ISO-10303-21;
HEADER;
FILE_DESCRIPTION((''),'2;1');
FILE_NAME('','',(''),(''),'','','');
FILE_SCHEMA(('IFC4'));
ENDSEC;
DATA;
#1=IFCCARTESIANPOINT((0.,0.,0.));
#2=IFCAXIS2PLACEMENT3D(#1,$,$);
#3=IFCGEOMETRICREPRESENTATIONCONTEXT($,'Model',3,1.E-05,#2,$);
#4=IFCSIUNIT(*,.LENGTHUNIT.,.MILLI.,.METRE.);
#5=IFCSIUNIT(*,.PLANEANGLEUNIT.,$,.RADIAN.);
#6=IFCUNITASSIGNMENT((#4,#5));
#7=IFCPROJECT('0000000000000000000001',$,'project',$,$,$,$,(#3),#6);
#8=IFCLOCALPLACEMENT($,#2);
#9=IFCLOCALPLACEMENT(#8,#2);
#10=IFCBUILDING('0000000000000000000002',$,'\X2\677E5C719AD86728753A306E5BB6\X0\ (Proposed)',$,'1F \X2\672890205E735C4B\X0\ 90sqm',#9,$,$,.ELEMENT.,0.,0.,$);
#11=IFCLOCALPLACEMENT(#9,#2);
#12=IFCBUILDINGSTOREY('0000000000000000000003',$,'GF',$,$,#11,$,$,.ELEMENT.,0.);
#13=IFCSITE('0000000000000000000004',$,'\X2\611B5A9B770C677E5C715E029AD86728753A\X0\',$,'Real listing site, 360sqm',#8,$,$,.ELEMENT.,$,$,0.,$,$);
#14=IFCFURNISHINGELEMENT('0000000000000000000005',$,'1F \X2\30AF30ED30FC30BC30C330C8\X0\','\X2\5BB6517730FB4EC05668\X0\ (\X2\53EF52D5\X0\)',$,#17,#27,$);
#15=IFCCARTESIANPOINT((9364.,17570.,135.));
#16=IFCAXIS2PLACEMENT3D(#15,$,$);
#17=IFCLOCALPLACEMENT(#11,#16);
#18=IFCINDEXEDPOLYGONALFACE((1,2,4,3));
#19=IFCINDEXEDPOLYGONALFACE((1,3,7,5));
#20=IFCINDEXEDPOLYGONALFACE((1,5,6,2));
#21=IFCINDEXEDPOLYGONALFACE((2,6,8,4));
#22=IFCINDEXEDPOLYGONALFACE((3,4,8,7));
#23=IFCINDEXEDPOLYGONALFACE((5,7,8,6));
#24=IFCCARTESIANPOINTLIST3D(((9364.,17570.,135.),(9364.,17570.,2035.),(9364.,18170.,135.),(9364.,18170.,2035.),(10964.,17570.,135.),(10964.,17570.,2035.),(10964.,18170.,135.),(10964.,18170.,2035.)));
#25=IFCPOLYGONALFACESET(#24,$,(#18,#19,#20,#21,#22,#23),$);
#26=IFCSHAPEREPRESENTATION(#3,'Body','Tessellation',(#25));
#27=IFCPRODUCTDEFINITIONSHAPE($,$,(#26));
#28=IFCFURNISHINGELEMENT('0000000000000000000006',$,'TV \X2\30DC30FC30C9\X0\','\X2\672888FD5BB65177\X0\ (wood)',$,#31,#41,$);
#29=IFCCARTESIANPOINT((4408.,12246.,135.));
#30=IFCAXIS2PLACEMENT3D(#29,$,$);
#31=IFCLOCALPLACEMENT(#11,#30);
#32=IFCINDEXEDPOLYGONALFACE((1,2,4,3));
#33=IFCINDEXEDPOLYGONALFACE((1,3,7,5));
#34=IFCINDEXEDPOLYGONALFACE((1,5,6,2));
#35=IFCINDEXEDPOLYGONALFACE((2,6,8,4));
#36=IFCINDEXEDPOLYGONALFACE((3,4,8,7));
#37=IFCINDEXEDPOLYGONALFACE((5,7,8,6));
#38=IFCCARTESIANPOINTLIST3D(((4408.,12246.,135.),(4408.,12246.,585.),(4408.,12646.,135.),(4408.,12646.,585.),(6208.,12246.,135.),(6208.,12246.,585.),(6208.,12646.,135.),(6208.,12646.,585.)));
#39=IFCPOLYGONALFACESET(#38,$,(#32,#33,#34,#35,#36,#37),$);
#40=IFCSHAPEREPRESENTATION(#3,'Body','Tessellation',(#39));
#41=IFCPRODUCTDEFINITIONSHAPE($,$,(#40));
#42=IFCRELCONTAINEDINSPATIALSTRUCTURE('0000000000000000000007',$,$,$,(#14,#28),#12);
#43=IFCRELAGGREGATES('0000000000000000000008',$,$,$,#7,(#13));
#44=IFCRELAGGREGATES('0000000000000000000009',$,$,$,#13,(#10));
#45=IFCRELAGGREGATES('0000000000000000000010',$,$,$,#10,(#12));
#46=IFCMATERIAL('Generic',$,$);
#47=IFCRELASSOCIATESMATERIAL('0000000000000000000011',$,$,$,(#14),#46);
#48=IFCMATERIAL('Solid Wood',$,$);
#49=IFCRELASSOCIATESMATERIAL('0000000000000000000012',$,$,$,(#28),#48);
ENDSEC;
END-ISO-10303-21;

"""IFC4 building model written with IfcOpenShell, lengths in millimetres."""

from ifc_helpers import new_model, si_unit, frame, frame_2d, origin, place, context, project, spatial, rectangle, extrude, material, element, save


model = new_model("IFC4")

# Units and contexts
model_context = context("Model", 3, precision=1e-05, world=origin())
ifc_project = project(units=[si_unit("LENGTHUNIT", "METRE", prefix="MILLI"), si_unit("PLANEANGLEUNIT", "RADIAN")], contexts=[model_context])

# Site, building, storey
site_placement = place(None, origin())
site = spatial("IfcSite", under=ifc_project, at=site_placement, Name="愛媛県松山市高木町", ObjectType="Real listing site, 360sqm", CompositionType="ELEMENT", RefElevation=0.0)
building_placement = place(site_placement, origin())
building = spatial("IfcBuilding", under=site, at=building_placement, Name="松山高木町の家 (Proposed)", ObjectType="1F 木造平屋 90sqm", CompositionType="ELEMENT", ElevationOfRefHeight=0.0, ElevationOfTerrain=0.0)
storey_placement = place(building_placement, origin())
storey = spatial("IfcBuildingStorey", under=building, at=storey_placement, Name="GF", CompositionType="ELEMENT", Elevation=0.0)

# Shared definitions
ifc_material_1 = material(Name="Solid Wood")

# Shared definitions
ifc_material_2 = material(Name="Generic")

# Furnishing elements
furnishing_1_placement = place(storey_placement, frame((9364.0, 17570.0, 135.0)))
element("IfcFurnishingElement", 1, at=furnishing_1_placement, inside=storey, material=ifc_material_2, Name="1F クローゼット", Description="家具・什器 (可動)", context=model_context, shape_type="SweptSolid", body=[
    extrude(rectangle(XDim=1600.0, YDim=600.0, at=frame_2d((800.0, 300.0))), frame((9364.0, 17570.0, 135.0)), (0.0, 0.0, 1.0), 1900.0),
])
furnishing_2_placement = place(storey_placement, frame((4408.0, 12246.0, 135.0)))
element("IfcFurnishingElement", 2, at=furnishing_2_placement, inside=storey, material=ifc_material_1, Name="TV ボード", Description="木製家具 (wood)", context=model_context, shape_type="SweptSolid", body=[
    extrude(rectangle(XDim=1800.0, YDim=400.0, at=frame_2d((900.0, 200.0))), frame((4408.0, 12246.0, 135.0)), (0.0, 0.0, 1.0), 450.0),
])

save(model, "model.ifc")
